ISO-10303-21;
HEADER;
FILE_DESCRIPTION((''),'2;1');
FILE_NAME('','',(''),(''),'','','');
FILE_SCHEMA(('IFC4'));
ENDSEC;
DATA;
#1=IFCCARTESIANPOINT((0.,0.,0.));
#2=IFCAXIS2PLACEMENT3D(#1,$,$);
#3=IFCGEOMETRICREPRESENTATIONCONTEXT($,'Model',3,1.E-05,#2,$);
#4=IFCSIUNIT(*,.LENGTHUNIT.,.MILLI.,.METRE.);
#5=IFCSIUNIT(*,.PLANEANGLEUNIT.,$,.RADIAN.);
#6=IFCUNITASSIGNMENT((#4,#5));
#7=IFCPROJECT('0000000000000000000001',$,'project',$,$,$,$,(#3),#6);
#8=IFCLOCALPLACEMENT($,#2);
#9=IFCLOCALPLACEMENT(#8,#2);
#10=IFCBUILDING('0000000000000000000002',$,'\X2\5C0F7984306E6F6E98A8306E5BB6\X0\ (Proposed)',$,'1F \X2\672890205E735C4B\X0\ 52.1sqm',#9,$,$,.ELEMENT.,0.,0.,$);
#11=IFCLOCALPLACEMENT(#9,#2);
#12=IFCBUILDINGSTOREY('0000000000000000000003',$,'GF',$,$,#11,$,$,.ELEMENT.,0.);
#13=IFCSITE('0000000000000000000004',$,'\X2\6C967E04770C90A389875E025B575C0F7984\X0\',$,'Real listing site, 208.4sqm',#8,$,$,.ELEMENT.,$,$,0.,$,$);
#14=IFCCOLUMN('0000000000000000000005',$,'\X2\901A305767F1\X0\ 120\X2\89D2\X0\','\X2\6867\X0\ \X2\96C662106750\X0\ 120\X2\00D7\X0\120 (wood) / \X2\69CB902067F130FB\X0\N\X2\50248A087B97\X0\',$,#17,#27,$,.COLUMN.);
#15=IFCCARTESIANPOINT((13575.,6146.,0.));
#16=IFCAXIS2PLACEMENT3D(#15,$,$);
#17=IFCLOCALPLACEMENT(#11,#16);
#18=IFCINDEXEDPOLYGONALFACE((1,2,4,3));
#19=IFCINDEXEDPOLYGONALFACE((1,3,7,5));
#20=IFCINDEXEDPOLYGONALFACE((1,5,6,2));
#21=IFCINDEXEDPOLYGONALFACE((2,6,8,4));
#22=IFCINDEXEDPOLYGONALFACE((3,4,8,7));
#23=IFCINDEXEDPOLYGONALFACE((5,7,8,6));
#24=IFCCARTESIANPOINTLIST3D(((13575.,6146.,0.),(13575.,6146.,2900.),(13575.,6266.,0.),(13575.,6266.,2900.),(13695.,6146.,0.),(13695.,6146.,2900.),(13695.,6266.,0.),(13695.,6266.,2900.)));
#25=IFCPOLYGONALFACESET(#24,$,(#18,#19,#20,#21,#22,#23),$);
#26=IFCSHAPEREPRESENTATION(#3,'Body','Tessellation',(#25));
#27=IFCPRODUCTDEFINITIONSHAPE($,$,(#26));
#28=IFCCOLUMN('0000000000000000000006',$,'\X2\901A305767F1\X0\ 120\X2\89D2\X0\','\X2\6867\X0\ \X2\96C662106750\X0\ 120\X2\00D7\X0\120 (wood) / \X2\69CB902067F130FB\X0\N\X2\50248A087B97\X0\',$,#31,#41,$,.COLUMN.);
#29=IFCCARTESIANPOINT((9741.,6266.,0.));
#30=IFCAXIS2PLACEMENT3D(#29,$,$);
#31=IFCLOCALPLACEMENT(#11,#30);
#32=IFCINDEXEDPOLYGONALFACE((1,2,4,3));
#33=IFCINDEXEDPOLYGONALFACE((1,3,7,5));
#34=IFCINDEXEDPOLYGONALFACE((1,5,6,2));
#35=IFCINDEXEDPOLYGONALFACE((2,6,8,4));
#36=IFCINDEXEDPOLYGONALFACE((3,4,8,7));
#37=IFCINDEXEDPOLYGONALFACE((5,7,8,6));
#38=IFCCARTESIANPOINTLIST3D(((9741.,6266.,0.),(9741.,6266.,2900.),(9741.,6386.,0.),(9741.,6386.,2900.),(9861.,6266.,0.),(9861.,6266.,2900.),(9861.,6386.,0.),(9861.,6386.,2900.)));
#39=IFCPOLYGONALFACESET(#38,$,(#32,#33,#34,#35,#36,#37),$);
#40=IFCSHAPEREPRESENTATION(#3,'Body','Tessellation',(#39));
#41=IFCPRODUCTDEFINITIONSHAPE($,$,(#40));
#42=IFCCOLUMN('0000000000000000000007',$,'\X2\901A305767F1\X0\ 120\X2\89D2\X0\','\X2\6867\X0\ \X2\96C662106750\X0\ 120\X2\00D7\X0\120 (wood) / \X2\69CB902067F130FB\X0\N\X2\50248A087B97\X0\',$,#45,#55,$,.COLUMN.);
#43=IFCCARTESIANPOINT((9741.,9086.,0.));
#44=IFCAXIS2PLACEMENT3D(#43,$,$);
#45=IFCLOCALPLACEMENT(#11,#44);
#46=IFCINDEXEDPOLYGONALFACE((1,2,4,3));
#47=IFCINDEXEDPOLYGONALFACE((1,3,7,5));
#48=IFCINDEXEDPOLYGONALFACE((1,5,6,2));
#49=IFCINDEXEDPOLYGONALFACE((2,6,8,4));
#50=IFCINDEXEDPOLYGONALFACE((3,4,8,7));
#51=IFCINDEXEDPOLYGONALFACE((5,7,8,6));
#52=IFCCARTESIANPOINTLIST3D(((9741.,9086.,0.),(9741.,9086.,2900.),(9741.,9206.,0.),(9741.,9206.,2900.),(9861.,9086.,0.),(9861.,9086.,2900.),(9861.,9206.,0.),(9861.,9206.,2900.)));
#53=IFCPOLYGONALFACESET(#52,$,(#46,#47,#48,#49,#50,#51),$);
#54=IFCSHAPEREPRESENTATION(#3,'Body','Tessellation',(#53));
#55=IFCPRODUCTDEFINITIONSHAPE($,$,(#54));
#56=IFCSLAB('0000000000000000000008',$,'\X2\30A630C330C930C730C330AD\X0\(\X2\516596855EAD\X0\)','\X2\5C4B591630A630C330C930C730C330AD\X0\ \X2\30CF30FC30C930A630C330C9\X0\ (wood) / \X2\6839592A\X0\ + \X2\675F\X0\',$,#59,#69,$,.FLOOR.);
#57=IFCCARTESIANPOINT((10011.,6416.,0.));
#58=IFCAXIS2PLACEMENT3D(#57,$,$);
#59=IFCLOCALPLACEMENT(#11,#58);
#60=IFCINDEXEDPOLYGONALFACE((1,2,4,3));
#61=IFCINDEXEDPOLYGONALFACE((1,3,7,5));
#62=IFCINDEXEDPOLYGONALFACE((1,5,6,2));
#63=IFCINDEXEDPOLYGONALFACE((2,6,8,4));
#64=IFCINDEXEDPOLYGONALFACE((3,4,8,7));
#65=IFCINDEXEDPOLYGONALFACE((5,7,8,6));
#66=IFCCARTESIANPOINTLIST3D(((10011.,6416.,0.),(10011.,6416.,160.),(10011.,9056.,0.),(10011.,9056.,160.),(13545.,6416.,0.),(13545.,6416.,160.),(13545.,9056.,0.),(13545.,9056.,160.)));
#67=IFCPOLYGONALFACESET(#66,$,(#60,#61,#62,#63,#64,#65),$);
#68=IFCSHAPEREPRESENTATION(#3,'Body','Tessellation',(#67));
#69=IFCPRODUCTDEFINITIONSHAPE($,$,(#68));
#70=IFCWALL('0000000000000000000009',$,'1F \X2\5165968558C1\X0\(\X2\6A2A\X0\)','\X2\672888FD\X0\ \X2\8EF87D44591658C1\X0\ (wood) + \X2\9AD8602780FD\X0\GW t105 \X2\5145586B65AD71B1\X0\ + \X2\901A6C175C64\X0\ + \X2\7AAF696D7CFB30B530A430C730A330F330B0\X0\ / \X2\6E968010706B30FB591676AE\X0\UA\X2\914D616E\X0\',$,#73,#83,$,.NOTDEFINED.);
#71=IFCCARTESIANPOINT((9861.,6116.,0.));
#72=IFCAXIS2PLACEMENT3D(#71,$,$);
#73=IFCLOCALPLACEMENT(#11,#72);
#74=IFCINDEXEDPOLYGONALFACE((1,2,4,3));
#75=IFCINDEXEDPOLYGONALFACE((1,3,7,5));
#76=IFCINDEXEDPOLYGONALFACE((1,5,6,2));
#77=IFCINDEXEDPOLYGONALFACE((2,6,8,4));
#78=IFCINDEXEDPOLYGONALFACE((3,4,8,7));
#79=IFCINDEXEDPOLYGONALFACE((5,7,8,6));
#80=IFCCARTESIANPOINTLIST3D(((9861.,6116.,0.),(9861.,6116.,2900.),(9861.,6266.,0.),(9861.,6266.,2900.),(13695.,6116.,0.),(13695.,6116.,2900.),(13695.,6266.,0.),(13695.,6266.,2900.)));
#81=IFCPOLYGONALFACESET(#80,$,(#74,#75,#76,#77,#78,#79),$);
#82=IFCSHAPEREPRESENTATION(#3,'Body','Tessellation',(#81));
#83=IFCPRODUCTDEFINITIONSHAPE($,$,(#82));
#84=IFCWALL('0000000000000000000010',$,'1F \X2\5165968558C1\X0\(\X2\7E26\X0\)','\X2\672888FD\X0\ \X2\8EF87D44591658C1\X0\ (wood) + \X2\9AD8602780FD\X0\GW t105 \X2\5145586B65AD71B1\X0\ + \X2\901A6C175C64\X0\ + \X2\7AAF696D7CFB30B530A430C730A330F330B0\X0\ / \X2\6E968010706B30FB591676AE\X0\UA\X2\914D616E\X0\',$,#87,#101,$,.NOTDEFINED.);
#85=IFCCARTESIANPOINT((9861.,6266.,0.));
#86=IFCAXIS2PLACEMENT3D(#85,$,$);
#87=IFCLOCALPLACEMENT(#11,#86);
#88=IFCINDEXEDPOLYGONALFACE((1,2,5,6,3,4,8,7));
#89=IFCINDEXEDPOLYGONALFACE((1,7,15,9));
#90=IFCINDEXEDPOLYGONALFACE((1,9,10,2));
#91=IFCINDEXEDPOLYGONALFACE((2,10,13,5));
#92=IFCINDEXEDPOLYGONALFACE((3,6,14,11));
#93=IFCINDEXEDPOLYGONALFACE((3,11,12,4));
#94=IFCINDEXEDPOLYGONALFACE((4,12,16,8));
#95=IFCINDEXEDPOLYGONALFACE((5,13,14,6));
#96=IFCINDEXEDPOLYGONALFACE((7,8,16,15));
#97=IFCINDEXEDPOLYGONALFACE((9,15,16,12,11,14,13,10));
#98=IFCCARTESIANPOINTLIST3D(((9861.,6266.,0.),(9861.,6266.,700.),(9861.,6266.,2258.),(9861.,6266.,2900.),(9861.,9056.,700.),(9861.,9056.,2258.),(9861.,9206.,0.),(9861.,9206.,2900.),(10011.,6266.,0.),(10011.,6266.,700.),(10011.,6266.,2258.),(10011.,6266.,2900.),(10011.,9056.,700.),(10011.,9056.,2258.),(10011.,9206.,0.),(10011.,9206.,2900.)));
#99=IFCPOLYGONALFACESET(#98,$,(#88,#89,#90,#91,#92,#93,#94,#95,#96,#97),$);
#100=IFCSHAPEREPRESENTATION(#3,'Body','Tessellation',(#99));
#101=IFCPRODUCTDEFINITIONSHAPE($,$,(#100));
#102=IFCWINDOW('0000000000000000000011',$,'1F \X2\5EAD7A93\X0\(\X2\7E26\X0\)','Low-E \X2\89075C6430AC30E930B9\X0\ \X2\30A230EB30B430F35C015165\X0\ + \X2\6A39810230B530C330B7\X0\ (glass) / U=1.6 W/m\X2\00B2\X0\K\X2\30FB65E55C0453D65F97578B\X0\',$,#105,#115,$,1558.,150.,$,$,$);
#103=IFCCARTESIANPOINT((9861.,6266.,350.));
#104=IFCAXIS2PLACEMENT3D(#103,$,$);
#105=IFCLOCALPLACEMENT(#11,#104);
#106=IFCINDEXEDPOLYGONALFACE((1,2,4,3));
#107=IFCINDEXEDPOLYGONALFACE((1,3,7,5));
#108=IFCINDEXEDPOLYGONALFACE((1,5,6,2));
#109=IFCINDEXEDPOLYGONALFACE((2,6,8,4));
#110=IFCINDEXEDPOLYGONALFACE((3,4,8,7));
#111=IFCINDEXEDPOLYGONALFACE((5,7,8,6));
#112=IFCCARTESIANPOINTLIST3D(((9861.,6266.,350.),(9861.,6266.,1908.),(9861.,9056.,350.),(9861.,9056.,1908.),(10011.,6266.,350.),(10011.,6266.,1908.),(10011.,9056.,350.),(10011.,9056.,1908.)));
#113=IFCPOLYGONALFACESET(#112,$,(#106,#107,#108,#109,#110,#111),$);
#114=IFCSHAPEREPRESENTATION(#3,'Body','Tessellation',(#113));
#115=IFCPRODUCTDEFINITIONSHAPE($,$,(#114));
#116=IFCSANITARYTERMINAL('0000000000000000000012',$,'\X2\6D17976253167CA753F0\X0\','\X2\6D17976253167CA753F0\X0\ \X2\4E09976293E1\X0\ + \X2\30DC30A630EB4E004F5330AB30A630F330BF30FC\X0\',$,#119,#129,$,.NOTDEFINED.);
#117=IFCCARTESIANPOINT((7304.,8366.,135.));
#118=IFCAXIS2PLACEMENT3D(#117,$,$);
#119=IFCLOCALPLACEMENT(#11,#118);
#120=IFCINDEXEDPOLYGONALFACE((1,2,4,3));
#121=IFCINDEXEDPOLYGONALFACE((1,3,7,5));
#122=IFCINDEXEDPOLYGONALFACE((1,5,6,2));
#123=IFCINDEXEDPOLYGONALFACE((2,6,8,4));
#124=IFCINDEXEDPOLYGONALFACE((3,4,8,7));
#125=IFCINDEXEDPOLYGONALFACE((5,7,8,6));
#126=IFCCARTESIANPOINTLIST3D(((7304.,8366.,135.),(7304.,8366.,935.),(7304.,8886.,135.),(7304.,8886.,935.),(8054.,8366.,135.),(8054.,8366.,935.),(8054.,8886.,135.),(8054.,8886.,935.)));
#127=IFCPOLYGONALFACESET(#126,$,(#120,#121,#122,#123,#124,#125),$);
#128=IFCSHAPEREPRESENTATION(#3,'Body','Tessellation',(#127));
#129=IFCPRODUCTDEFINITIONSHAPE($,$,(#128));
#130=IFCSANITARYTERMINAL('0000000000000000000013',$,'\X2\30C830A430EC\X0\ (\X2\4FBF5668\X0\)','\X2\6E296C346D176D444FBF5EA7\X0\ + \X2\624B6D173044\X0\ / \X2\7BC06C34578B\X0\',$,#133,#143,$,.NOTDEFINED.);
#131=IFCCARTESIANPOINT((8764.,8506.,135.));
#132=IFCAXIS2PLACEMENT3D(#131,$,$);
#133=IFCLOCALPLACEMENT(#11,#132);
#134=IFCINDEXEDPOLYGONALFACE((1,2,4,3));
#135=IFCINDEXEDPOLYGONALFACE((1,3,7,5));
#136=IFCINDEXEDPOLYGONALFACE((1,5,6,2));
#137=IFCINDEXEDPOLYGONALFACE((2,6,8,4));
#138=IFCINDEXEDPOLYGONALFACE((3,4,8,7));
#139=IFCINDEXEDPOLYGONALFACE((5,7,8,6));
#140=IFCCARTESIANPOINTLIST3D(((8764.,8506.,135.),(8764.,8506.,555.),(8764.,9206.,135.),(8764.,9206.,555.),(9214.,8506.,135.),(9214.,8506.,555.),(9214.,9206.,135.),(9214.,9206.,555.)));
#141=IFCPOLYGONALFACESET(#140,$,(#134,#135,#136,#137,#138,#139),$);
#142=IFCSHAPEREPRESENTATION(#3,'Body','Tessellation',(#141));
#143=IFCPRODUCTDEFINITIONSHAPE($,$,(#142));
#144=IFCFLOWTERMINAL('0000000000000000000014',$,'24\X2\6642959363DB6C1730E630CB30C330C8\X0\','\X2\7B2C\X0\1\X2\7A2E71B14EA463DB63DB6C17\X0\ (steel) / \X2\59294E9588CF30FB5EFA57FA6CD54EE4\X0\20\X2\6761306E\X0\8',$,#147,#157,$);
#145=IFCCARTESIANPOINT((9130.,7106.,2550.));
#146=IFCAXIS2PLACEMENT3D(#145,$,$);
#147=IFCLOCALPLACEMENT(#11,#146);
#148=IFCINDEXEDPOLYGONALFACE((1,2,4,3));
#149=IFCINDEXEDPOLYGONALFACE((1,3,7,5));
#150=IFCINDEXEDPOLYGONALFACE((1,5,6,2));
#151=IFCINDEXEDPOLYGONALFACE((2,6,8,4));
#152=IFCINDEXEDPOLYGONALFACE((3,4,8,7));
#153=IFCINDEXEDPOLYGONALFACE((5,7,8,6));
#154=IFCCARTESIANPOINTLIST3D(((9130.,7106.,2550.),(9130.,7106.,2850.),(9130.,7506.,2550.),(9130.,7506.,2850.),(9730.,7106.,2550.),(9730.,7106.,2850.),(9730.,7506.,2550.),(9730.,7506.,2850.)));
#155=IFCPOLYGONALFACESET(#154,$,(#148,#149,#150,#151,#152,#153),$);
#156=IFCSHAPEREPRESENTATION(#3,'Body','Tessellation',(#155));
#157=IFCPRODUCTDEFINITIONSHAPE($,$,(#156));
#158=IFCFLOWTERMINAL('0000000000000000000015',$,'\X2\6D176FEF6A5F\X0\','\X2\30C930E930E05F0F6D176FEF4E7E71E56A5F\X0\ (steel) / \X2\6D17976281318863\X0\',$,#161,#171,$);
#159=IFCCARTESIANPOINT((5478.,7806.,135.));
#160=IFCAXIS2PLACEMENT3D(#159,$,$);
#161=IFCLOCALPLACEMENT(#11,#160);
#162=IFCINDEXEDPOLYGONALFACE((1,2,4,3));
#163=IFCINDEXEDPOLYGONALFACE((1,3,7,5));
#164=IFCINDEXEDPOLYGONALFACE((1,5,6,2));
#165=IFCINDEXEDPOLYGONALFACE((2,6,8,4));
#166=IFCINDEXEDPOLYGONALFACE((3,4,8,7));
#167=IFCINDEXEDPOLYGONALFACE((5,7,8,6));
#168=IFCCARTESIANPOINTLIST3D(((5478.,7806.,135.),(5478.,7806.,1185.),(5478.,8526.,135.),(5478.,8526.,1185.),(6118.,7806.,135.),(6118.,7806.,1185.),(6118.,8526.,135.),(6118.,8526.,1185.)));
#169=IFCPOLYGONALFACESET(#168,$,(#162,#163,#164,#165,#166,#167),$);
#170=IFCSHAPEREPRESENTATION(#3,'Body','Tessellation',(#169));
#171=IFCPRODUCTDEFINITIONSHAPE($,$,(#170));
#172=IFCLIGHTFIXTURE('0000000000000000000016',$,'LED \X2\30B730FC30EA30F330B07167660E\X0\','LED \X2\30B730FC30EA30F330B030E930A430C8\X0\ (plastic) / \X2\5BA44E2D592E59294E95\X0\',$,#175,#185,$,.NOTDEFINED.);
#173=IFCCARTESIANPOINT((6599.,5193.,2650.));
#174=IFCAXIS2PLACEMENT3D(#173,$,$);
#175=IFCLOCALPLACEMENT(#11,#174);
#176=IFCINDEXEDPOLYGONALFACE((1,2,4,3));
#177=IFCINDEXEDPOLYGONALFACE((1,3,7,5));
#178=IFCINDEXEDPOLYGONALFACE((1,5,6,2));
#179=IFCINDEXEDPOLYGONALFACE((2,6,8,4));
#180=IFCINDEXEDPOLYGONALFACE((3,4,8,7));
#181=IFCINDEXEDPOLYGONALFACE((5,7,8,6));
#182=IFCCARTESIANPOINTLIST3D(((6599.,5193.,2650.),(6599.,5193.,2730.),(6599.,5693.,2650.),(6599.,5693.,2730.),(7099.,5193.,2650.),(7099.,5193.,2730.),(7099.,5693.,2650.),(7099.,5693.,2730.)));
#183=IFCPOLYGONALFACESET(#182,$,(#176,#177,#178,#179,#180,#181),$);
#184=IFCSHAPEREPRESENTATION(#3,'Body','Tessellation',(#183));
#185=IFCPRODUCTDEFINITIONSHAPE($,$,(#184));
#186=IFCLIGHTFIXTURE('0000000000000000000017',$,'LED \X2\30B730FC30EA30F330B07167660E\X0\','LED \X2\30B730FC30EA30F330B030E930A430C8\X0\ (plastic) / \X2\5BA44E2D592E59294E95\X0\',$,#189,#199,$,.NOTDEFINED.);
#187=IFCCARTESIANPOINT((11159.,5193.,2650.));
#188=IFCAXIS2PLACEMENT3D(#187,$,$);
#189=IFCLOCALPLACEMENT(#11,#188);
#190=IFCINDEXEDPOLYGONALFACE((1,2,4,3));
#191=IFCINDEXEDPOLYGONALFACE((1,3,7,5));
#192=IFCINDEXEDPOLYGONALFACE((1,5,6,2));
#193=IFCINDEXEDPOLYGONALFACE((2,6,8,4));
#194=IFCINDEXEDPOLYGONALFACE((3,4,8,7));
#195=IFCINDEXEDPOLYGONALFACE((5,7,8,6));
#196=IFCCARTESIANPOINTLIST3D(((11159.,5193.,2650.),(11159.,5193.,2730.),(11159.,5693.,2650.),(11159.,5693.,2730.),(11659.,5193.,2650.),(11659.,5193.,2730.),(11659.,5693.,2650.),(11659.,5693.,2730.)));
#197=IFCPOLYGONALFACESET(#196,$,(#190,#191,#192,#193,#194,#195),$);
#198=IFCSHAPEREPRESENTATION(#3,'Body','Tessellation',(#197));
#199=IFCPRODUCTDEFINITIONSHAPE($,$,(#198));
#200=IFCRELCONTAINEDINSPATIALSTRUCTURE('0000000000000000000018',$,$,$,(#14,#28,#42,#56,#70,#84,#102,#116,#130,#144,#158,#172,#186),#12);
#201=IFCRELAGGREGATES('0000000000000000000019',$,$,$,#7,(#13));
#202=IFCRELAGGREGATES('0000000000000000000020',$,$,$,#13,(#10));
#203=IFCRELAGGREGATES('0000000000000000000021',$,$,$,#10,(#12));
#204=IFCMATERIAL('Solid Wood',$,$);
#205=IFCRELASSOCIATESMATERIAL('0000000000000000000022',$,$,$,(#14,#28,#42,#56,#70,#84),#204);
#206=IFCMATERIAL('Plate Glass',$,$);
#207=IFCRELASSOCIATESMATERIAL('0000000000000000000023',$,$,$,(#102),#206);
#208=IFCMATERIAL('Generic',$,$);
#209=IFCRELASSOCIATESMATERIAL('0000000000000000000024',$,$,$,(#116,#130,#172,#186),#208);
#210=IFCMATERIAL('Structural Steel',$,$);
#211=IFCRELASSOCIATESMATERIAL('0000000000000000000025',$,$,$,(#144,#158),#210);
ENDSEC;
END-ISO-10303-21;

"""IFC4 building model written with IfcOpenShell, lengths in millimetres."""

from ifc_helpers import new_model, si_unit, frame, frame_2d, origin, place, context, project, spatial, rectangle, extrude, material, element, fill, save


model = new_model("IFC4")

# Units and contexts
model_context = context("Model", 3, precision=1e-05, world=origin())
ifc_project = project(units=[si_unit("LENGTHUNIT", "METRE", prefix="MILLI"), si_unit("PLANEANGLEUNIT", "RADIAN")], contexts=[model_context])

# Site, building, storey
site_placement = place(None, origin())
site = spatial("IfcSite", under=ifc_project, at=site_placement, Name="沖縄県那覇市字小禄", ObjectType="Real listing site, 208.4sqm", CompositionType="ELEMENT", RefElevation=0.0)
building_placement = place(site_placement, origin())
building = spatial("IfcBuilding", under=site, at=building_placement, Name="小禄の潮風の家 (Proposed)", ObjectType="1F 木造平屋 52.1sqm", CompositionType="ELEMENT", ElevationOfRefHeight=0.0, ElevationOfTerrain=0.0)
storey_placement = place(building_placement, origin())
storey = spatial("IfcBuildingStorey", under=building, at=storey_placement, Name="GF", CompositionType="ELEMENT", Elevation=0.0)

# Columns
ifc_material_1 = material(Name="Solid Wood")
column_1_placement = place(storey_placement, frame((13575.0, 6146.0, 0.0)))
element("IfcColumn", 1, at=column_1_placement, inside=storey, material=ifc_material_1, Name="通し柱 120角", Description="桧 集成材 120×120 (wood) / 構造柱・N値計算", PredefinedType="COLUMN", context=model_context, shape_type="SweptSolid", body=[
    extrude(rectangle(XDim=120.0, YDim=120.0, at=frame_2d((60.0, 60.0))), frame((13575.0, 6146.0, 0.0)), (0.0, 0.0, 1.0), 2900.0),
])
column_2_placement = place(storey_placement, frame((9741.0, 6266.0, 0.0)))
element("IfcColumn", 2, at=column_2_placement, inside=storey, material=ifc_material_1, Name="通し柱 120角", Description="桧 集成材 120×120 (wood) / 構造柱・N値計算", PredefinedType="COLUMN", context=model_context, shape_type="SweptSolid", body=[
    extrude(rectangle(XDim=120.0, YDim=120.0, at=frame_2d((60.0, 60.0))), frame((9741.0, 6266.0, 0.0)), (0.0, 0.0, 1.0), 2900.0),
])
column_3_placement = place(storey_placement, frame((9741.0, 9086.0, 0.0)))
element("IfcColumn", 3, at=column_3_placement, inside=storey, material=ifc_material_1, Name="通し柱 120角", Description="桧 集成材 120×120 (wood) / 構造柱・N値計算", PredefinedType="COLUMN", context=model_context, shape_type="SweptSolid", body=[
    extrude(rectangle(XDim=120.0, YDim=120.0, at=frame_2d((60.0, 60.0))), frame((9741.0, 9086.0, 0.0)), (0.0, 0.0, 1.0), 2900.0),
])

# Slab
slab_placement = place(storey_placement, frame((10011.0, 6416.0, 0.0)))
element("IfcSlab", 4, at=slab_placement, inside=storey, material=ifc_material_1, Name="ウッドデッキ(入隅庭)", Description="屋外ウッドデッキ ハードウッド (wood) / 根太 + 束", PredefinedType="FLOOR", context=model_context, shape_type="SweptSolid", body=[
    extrude(rectangle(XDim=3534.0, YDim=2640.0, at=frame_2d((1767.0, 1320.0))), frame((10011.0, 6416.0, 0.0)), (0.0, 0.0, 1.0), 160.0),
])

# Wall
wall_1_placement = place(storey_placement, frame((9861.0, 6116.0, 0.0)))
element("IfcWall", 5, at=wall_1_placement, inside=storey, material=ifc_material_1, Name="1F 入隅壁(横)", Description="木製 軸組外壁 (wood) + 高性能GW t105 充填断熱 + 通気層 + 窯業系サイディング / 準耐火・外皮UA配慮", PredefinedType="NOTDEFINED", context=model_context, shape_type="SweptSolid", body=[
    extrude(rectangle(XDim=3834.0, YDim=150.0, at=frame_2d((1917.0, 75.0))), frame((9861.0, 6116.0, 0.0)), (0.0, 0.0, 1.0), 2900.0),
])

# Wall, opening, window
wall_2_placement = place(storey_placement, frame((9861.0, 6266.0, 0.0)))
wall_2 = element("IfcWall", 6, at=wall_2_placement, inside=storey, material=ifc_material_1, Name="1F 入隅壁(縦)", Description="木製 軸組外壁 (wood) + 高性能GW t105 充填断熱 + 通気層 + 窯業系サイディング / 準耐火・外皮UA配慮", PredefinedType="NOTDEFINED", context=model_context, shape_type="SweptSolid", body=[
    extrude(rectangle(XDim=150.0, YDim=2940.0, at=frame_2d((75.0, 1470.0))), frame((9861.0, 6266.0, 0.0)), (0.0, 0.0, 1.0), 2900.0),
])
opening_placement = place(storey_placement, frame((9861.0, 6266.0, 350.0)))
opening = element("IfcOpeningElement", 7, at=opening_placement, cuts=wall_2, PredefinedType="NOTDEFINED", context=model_context, shape_type="SweptSolid", body=[
    extrude(rectangle(XDim=150.0, YDim=2790.0, at=frame_2d((75.0, 1395.0))), frame((9861.0, 6266.0, 350.0)), (0.0, 0.0, 1.0), 1558.0),
])
ifc_material_2 = material(Name="Plate Glass")
window_placement = place(storey_placement, frame((9861.0, 6266.0, 350.0)))
window = element("IfcWindow", 8, at=window_placement, inside=storey, material=ifc_material_2, Name="1F 庭窓(縦)", Description="Low-E 複層ガラス アルゴン封入 + 樹脂サッシ (glass) / U=1.6 W/m²K・日射取得型", OverallHeight=1558.0, OverallWidth=150.0, context=model_context, shape_type="SweptSolid", body=[
    extrude(rectangle(XDim=150.0, YDim=2790.0, at=frame_2d((75.0, 1395.0))), frame((9861.0, 6266.0, 350.0)), (0.0, 0.0, 1.0), 1558.0),
])
fill(opening, window)

# Sanitary terminals
ifc_material_3 = material(Name="Generic")
sanitary_terminal_1_placement = place(storey_placement, frame((7304.0, 8366.0, 135.0)))
element("IfcSanitaryTerminal", 9, at=sanitary_terminal_1_placement, inside=storey, material=ifc_material_3, Name="洗面化粧台", Description="洗面化粧台 三面鏡 + ボウル一体カウンター", PredefinedType="NOTDEFINED", context=model_context, shape_type="SweptSolid", body=[
    extrude(rectangle(XDim=750.0, YDim=520.0, at=frame_2d((375.0, 260.0))), frame((7304.0, 8366.0, 135.0)), (0.0, 0.0, 1.0), 800.0),
])
sanitary_terminal_2_placement = place(storey_placement, frame((8764.0, 8506.0, 135.0)))
element("IfcSanitaryTerminal", 10, at=sanitary_terminal_2_placement, inside=storey, material=ifc_material_3, Name="トイレ (便器)", Description="温水洗浄便座 + 手洗い / 節水型", PredefinedType="NOTDEFINED", context=model_context, shape_type="SweptSolid", body=[
    extrude(rectangle(XDim=450.0, YDim=700.0, at=frame_2d((225.0, 350.0))), frame((8764.0, 8506.0, 135.0)), (0.0, 0.0, 1.0), 420.0),
])

# Flow terminals
ifc_material_4 = material(Name="Structural Steel")
flow_terminal_1_placement = place(storey_placement, frame((9130.0, 7106.0, 2550.0)))
element("IfcFlowTerminal", 11, at=flow_terminal_1_placement, inside=storey, material=ifc_material_4, Name="24時間換気ユニット", Description="第1種熱交換換気 (steel) / 天井裏・建基法令20条の8", context=model_context, shape_type="SweptSolid", body=[
    extrude(rectangle(XDim=600.0, YDim=400.0, at=frame_2d((300.0, 200.0))), frame((9130.0, 7106.0, 2550.0)), (0.0, 0.0, 1.0), 300.0),
])
flow_terminal_2_placement = place(storey_placement, frame((5478.0, 7806.0, 135.0)))
element("IfcFlowTerminal", 12, at=flow_terminal_2_placement, inside=storey, material=ifc_material_4, Name="洗濯機", Description="ドラム式洗濯乾燥機 (steel) / 洗面脱衣", context=model_context, shape_type="SweptSolid", body=[
    extrude(rectangle(XDim=640.0, YDim=720.0, at=frame_2d((320.0, 360.0))), frame((5478.0, 7806.0, 135.0)), (0.0, 0.0, 1.0), 1050.0),
])

# Light fixtures
light_fixture_1_placement = place(storey_placement, frame((6599.0, 5193.0, 2650.0)))
element("IfcLightFixture", 13, at=light_fixture_1_placement, inside=storey, material=ifc_material_3, Name="LED シーリング照明", Description="LED シーリングライト (plastic) / 室中央天井", PredefinedType="NOTDEFINED", context=model_context, shape_type="SweptSolid", body=[
    extrude(rectangle(XDim=500.0, YDim=500.0, at=frame_2d((250.0, 250.0))), frame((6599.0, 5193.0, 2650.0)), (0.0, 0.0, 1.0), 80.0),
])
light_fixture_2_placement = place(storey_placement, frame((11159.0, 5193.0, 2650.0)))
element("IfcLightFixture", 14, at=light_fixture_2_placement, inside=storey, material=ifc_material_3, Name="LED シーリング照明", Description="LED シーリングライト (plastic) / 室中央天井", PredefinedType="NOTDEFINED", context=model_context, shape_type="SweptSolid", body=[
    extrude(rectangle(XDim=500.0, YDim=500.0, at=frame_2d((250.0, 250.0))), frame((11159.0, 5193.0, 2650.0)), (0.0, 0.0, 1.0), 80.0),
])

save(model, "model.ifc")
